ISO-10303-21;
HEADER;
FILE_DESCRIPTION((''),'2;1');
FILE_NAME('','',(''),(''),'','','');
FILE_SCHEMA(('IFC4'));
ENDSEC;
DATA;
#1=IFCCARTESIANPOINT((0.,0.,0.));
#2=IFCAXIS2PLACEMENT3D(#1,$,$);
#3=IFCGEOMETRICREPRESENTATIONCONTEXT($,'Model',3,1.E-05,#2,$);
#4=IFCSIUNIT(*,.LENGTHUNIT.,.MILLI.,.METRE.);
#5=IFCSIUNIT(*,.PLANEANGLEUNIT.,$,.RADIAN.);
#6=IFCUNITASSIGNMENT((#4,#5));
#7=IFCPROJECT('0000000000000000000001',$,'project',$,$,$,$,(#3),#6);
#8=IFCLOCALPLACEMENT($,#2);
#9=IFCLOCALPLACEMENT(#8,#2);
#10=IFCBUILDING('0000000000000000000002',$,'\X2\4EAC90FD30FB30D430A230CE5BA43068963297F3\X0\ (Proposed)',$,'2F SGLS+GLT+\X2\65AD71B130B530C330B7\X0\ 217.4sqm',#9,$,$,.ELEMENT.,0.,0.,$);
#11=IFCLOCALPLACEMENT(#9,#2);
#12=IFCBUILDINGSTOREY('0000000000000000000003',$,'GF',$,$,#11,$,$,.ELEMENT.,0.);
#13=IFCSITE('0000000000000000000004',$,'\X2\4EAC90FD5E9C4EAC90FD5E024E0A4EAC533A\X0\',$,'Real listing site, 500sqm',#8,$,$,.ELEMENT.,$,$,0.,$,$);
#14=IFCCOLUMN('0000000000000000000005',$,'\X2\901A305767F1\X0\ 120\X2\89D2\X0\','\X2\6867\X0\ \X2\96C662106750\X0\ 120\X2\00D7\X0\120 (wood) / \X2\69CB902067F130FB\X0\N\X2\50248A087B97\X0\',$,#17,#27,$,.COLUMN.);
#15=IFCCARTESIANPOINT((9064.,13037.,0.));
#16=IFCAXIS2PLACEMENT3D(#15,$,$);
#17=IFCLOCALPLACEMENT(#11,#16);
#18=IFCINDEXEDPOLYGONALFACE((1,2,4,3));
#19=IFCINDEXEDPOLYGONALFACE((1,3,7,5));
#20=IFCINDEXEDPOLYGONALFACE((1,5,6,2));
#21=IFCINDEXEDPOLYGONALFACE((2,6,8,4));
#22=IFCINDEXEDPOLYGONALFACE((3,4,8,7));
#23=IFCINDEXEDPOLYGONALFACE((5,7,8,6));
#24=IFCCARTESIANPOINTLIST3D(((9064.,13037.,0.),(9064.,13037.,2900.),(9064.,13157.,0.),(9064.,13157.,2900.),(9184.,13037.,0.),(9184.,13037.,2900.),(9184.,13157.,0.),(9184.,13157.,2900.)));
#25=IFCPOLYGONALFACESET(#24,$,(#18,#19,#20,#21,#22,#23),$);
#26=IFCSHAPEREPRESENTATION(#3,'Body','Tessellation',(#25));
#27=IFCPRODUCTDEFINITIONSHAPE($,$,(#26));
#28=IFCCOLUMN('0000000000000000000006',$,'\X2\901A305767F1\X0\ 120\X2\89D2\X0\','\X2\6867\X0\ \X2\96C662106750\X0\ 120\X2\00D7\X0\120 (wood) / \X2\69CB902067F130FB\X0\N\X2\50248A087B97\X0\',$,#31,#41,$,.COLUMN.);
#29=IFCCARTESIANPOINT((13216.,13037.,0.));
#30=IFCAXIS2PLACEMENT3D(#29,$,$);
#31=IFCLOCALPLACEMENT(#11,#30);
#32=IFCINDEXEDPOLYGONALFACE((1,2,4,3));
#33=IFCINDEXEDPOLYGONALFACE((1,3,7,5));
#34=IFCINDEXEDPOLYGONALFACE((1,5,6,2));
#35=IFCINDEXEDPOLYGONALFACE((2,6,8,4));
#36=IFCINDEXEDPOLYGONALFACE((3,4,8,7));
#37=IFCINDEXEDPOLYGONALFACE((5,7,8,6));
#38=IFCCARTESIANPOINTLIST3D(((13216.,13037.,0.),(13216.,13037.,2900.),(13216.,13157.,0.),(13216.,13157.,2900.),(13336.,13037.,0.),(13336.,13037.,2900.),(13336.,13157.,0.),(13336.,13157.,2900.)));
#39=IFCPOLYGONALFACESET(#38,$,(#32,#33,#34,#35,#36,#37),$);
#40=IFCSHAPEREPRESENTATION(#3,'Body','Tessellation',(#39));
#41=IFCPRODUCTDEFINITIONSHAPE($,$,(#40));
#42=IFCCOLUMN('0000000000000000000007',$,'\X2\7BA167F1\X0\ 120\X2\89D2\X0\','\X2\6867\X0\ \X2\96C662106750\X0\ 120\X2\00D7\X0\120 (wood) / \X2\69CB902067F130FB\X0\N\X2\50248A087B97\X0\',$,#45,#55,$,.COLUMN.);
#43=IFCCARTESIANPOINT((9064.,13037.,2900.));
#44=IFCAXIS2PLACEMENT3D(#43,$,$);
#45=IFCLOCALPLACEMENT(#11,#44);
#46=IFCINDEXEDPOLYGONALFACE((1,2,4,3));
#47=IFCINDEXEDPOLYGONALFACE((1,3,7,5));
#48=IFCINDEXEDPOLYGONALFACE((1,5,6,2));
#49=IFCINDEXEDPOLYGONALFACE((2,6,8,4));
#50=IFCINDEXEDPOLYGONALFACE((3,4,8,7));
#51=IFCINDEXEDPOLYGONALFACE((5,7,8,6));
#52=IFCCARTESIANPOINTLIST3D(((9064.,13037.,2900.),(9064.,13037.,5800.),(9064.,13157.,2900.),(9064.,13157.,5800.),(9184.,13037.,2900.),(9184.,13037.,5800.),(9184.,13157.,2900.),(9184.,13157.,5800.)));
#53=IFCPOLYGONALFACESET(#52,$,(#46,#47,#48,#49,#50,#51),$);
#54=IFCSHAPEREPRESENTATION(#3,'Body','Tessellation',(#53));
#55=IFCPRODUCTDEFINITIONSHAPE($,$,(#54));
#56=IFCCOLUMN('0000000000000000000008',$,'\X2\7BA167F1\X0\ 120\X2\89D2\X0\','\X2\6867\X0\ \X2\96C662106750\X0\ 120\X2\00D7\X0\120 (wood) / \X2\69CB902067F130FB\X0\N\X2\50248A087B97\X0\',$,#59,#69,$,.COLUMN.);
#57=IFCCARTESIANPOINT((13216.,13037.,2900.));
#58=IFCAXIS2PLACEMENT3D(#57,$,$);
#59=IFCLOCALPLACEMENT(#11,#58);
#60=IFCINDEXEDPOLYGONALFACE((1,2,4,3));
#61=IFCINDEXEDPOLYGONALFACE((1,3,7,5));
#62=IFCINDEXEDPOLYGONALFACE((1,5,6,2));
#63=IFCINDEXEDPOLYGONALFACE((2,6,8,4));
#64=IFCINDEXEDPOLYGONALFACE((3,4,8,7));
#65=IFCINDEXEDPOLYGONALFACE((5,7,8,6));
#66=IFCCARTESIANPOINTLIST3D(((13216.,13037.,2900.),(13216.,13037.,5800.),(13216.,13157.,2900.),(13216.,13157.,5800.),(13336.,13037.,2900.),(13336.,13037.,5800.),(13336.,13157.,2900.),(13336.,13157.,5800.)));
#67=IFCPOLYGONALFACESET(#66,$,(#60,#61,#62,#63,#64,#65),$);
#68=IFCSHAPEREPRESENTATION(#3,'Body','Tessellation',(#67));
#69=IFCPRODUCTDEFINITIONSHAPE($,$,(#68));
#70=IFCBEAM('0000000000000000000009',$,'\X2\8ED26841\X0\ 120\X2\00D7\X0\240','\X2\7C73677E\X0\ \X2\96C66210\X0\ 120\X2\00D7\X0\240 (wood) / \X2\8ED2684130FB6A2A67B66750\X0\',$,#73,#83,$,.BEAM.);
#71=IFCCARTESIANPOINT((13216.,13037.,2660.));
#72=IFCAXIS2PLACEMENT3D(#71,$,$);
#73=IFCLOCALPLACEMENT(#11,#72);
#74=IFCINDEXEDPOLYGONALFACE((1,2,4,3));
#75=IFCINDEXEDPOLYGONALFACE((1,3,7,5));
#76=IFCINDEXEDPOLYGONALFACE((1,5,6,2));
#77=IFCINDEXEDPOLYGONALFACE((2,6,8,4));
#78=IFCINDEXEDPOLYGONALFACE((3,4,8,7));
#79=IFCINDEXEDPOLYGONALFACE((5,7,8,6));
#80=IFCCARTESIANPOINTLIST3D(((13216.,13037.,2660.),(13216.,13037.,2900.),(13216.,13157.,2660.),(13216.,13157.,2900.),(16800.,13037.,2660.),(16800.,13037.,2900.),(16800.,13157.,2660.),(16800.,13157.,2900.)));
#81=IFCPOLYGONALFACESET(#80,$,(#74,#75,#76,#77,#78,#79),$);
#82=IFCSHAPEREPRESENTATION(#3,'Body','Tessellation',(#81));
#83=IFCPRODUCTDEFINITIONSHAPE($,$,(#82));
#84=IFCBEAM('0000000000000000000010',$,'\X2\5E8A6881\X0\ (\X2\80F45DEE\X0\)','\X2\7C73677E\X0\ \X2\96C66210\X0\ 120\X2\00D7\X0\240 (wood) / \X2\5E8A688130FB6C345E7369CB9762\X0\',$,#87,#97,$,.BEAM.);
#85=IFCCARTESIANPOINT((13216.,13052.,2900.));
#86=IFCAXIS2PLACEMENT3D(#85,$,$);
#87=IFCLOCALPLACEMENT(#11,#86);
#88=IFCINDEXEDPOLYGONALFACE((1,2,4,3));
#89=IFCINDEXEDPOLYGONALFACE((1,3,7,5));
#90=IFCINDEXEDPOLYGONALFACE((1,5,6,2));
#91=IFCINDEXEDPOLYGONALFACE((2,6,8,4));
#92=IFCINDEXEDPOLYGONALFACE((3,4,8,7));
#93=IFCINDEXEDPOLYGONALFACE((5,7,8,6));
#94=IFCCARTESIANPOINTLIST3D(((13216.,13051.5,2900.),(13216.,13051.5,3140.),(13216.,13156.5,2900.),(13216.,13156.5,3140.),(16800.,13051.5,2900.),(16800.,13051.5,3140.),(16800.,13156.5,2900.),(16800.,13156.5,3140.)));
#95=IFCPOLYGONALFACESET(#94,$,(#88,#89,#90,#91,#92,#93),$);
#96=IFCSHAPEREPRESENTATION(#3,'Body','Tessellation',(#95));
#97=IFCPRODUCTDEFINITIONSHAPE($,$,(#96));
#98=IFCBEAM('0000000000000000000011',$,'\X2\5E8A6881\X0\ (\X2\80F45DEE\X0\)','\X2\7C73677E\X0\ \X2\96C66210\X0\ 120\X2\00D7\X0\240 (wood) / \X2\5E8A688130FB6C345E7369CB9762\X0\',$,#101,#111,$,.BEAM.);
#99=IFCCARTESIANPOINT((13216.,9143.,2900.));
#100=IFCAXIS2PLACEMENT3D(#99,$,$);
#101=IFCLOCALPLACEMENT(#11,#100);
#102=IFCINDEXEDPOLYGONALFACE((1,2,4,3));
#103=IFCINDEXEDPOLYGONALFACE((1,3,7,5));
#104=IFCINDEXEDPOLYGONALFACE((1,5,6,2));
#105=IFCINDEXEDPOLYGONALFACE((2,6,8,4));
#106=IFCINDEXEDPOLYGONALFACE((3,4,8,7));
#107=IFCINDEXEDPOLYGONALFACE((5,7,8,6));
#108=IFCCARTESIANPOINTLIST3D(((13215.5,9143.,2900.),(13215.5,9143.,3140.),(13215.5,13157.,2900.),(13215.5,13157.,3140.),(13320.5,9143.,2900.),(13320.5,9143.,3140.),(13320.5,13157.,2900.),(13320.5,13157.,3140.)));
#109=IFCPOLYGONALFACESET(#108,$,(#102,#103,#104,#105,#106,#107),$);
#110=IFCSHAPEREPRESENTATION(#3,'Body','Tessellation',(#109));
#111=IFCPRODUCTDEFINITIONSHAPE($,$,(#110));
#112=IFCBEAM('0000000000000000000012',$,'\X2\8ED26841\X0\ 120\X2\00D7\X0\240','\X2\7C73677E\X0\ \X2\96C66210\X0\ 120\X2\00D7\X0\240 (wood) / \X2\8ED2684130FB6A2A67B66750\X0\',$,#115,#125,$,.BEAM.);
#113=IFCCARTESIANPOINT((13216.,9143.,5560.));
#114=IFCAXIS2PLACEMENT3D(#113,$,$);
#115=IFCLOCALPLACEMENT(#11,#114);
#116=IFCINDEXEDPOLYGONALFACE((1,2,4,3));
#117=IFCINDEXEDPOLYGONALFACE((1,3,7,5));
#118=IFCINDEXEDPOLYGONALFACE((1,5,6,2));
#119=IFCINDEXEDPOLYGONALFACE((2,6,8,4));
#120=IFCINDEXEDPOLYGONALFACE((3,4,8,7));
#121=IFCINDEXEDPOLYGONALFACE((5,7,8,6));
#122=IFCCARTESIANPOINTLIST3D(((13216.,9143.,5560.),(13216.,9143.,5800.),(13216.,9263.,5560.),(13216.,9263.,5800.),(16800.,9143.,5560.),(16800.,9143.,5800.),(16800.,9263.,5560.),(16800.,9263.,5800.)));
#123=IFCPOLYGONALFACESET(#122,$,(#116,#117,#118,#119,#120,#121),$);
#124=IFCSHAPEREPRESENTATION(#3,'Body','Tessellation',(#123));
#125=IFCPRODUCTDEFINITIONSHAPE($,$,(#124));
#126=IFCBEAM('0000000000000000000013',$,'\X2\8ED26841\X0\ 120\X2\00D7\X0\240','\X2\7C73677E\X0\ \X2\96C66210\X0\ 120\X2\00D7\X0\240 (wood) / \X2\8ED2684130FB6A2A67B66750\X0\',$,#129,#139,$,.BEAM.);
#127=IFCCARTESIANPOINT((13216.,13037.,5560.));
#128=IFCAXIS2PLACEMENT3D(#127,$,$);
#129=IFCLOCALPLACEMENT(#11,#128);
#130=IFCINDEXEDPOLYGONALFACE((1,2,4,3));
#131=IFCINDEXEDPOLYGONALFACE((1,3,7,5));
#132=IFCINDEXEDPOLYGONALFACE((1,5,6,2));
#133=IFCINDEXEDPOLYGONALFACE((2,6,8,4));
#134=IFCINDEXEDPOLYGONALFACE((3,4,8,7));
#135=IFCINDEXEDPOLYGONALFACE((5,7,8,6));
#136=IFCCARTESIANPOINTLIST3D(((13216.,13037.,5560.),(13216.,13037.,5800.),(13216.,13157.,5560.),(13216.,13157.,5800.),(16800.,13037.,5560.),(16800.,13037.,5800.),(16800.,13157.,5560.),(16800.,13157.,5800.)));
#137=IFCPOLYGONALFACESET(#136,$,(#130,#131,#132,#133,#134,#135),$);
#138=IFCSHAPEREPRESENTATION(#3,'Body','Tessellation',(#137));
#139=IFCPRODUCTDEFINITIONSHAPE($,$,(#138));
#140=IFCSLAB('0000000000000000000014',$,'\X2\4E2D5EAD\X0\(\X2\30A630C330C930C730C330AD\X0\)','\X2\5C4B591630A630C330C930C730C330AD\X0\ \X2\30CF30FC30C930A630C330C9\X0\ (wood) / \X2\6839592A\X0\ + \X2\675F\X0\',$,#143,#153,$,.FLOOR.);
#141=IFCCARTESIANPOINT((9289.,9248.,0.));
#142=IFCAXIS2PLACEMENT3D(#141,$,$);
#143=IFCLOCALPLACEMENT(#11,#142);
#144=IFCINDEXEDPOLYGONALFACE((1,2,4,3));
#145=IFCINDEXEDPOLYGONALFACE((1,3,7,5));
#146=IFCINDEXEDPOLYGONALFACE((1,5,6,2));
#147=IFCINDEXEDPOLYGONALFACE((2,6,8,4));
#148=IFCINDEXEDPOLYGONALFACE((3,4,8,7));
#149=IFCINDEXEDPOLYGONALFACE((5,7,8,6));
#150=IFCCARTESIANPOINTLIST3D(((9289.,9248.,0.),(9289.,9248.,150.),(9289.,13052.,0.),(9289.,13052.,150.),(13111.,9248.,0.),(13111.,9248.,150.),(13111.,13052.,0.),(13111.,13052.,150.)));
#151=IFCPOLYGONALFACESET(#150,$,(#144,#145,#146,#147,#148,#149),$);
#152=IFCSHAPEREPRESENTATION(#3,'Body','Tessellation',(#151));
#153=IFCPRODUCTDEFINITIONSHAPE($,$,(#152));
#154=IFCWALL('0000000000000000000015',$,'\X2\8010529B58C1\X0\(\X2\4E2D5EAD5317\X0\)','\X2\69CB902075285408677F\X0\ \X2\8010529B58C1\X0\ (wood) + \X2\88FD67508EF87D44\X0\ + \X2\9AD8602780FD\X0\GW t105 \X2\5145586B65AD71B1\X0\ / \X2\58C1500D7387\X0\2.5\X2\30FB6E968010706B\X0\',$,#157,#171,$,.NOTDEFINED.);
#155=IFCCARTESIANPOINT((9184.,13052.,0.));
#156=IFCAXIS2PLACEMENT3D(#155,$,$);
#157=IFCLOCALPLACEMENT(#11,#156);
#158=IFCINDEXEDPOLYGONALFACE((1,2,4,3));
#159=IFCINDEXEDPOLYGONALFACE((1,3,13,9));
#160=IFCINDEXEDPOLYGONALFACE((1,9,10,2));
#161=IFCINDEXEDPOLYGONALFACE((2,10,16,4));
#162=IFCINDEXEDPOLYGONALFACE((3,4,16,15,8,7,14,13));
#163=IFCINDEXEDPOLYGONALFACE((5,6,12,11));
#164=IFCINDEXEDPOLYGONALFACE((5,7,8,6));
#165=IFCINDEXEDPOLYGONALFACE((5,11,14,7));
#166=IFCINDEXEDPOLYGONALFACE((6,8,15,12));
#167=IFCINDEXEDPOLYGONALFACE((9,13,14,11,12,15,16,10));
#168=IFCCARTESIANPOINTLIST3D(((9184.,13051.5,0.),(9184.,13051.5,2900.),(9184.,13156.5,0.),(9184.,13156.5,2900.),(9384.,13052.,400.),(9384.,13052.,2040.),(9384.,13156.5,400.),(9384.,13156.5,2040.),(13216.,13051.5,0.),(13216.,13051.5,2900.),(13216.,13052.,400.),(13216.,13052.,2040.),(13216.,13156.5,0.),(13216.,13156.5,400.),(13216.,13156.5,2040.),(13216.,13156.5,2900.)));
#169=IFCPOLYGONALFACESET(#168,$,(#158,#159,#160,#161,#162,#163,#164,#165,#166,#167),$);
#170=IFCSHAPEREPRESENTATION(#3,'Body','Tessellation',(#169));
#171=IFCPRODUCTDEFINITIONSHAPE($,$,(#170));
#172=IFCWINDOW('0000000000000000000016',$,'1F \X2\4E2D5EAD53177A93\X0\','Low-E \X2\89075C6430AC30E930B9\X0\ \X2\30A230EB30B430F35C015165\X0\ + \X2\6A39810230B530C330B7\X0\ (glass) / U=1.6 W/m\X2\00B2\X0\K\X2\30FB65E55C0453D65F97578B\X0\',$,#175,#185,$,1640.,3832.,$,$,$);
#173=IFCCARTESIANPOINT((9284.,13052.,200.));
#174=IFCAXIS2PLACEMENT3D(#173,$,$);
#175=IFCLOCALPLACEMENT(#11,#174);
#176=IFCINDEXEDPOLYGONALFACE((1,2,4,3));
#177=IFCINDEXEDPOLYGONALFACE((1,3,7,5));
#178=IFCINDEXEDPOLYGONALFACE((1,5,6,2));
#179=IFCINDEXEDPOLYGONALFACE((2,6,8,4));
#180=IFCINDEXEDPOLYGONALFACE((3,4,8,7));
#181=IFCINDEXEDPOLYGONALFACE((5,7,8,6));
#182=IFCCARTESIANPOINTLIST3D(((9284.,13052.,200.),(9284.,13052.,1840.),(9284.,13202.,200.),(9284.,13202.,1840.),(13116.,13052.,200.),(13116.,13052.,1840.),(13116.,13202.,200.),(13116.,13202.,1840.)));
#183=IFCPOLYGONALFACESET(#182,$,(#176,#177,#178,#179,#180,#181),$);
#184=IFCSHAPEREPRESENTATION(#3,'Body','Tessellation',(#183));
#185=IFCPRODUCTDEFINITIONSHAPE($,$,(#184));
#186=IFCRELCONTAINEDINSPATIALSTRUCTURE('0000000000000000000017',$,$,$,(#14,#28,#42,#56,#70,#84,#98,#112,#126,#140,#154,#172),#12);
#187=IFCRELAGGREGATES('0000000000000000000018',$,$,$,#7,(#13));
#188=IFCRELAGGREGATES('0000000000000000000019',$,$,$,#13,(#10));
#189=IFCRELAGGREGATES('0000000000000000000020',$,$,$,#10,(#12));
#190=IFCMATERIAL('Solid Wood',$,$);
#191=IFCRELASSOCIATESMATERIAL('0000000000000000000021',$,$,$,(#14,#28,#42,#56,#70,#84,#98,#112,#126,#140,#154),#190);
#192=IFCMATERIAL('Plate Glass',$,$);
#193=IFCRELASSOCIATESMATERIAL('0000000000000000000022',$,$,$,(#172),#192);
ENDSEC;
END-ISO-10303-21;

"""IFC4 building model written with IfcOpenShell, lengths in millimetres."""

from ifc_helpers import new_model, si_unit, frame, frame_2d, origin, place, context, project, spatial, rectangle, extrude, material, element, fill, save


model = new_model("IFC4")

# Units and contexts
model_context = context("Model", 3, precision=1e-05, world=origin())
ifc_project = project(units=[si_unit("LENGTHUNIT", "METRE", prefix="MILLI"), si_unit("PLANEANGLEUNIT", "RADIAN")], contexts=[model_context])

# Site, building, storey
site_placement = place(None, origin())
site = spatial("IfcSite", under=ifc_project, at=site_placement, Name="京都府京都市上京区", ObjectType="Real listing site, 500sqm", CompositionType="ELEMENT", RefElevation=0.0)
building_placement = place(site_placement, origin())
building = spatial("IfcBuilding", under=site, at=building_placement, Name="京都・ピアノ室と防音 (Proposed)", ObjectType="2F SGLS+GLT+断熱サッシ 217.4sqm", CompositionType="ELEMENT", ElevationOfRefHeight=0.0, ElevationOfTerrain=0.0)
storey_placement = place(building_placement, origin())
storey = spatial("IfcBuildingStorey", under=building, at=storey_placement, Name="GF", CompositionType="ELEMENT", Elevation=0.0)

# Columns
ifc_material_1 = material(Name="Solid Wood")
column_1_placement = place(storey_placement, frame((9064.0, 13037.0, 0.0)))
element("IfcColumn", 1, at=column_1_placement, inside=storey, material=ifc_material_1, Name="通し柱 120角", Description="桧 集成材 120×120 (wood) / 構造柱・N値計算", PredefinedType="COLUMN", context=model_context, shape_type="SweptSolid", body=[
    extrude(rectangle(XDim=120.0, YDim=120.0, at=frame_2d((60.0, 60.0))), frame((9064.0, 13037.0, 0.0)), (0.0, 0.0, 1.0), 2900.0),
])
column_2_placement = place(storey_placement, frame((13216.0, 13037.0, 0.0)))
element("IfcColumn", 2, at=column_2_placement, inside=storey, material=ifc_material_1, Name="通し柱 120角", Description="桧 集成材 120×120 (wood) / 構造柱・N値計算", PredefinedType="COLUMN", context=model_context, shape_type="SweptSolid", body=[
    extrude(rectangle(XDim=120.0, YDim=120.0, at=frame_2d((60.0, 60.0))), frame((13216.0, 13037.0, 0.0)), (0.0, 0.0, 1.0), 2900.0),
])
column_3_placement = place(storey_placement, frame((9064.0, 13037.0, 2900.0)))
element("IfcColumn", 3, at=column_3_placement, inside=storey, material=ifc_material_1, Name="管柱 120角", Description="桧 集成材 120×120 (wood) / 構造柱・N値計算", PredefinedType="COLUMN", context=model_context, shape_type="SweptSolid", body=[
    extrude(rectangle(XDim=120.0, YDim=120.0, at=frame_2d((60.0, 60.0))), frame((9064.0, 13037.0, 2900.0)), (0.0, 0.0, 1.0), 2900.0),
])
column_4_placement = place(storey_placement, frame((13216.0, 13037.0, 2900.0)))
element("IfcColumn", 4, at=column_4_placement, inside=storey, material=ifc_material_1, Name="管柱 120角", Description="桧 集成材 120×120 (wood) / 構造柱・N値計算", PredefinedType="COLUMN", context=model_context, shape_type="SweptSolid", body=[
    extrude(rectangle(XDim=120.0, YDim=120.0, at=frame_2d((60.0, 60.0))), frame((13216.0, 13037.0, 2900.0)), (0.0, 0.0, 1.0), 2900.0),
])

# Beams
beam_1_placement = place(storey_placement, frame((13216.0, 13037.0, 2660.0)))
element("IfcBeam", 5, at=beam_1_placement, inside=storey, material=ifc_material_1, Name="軒桁 120×240", Description="米松 集成 120×240 (wood) / 軒桁・横架材", PredefinedType="BEAM", context=model_context, shape_type="SweptSolid", body=[
    extrude(rectangle(XDim=3584.0, YDim=120.0, at=frame_2d((1792.0, 60.0))), frame((13216.0, 13037.0, 2660.0)), (0.0, 0.0, 1.0), 240.0),
])
beam_2_placement = place(storey_placement, frame((13216.0, 13052.0, 2900.0)))
element("IfcBeam", 6, at=beam_2_placement, inside=storey, material=ifc_material_1, Name="床梁 (胴差)", Description="米松 集成 120×240 (wood) / 床梁・水平構面", PredefinedType="BEAM", context=model_context, shape_type="SweptSolid", body=[
    extrude(rectangle(XDim=3584.0, YDim=105.0, at=frame_2d((1792.0, 52.0))), frame((13216.0, 13052.0, 2900.0)), (0.0, 0.0, 1.0), 240.0),
])
beam_3_placement = place(storey_placement, frame((13216.0, 9143.0, 2900.0)))
element("IfcBeam", 7, at=beam_3_placement, inside=storey, material=ifc_material_1, Name="床梁 (胴差)", Description="米松 集成 120×240 (wood) / 床梁・水平構面", PredefinedType="BEAM", context=model_context, shape_type="SweptSolid", body=[
    extrude(rectangle(XDim=105.0, YDim=4014.0, at=frame_2d((52.0, 2007.0))), frame((13216.0, 9143.0, 2900.0)), (0.0, 0.0, 1.0), 240.0),
])
beam_4_placement = place(storey_placement, frame((13216.0, 9143.0, 5560.0)))
element("IfcBeam", 8, at=beam_4_placement, inside=storey, material=ifc_material_1, Name="軒桁 120×240", Description="米松 集成 120×240 (wood) / 軒桁・横架材", PredefinedType="BEAM", context=model_context, shape_type="SweptSolid", body=[
    extrude(rectangle(XDim=3584.0, YDim=120.0, at=frame_2d((1792.0, 60.0))), frame((13216.0, 9143.0, 5560.0)), (0.0, 0.0, 1.0), 240.0),
])
beam_5_placement = place(storey_placement, frame((13216.0, 13037.0, 5560.0)))
element("IfcBeam", 9, at=beam_5_placement, inside=storey, material=ifc_material_1, Name="軒桁 120×240", Description="米松 集成 120×240 (wood) / 軒桁・横架材", PredefinedType="BEAM", context=model_context, shape_type="SweptSolid", body=[
    extrude(rectangle(XDim=3584.0, YDim=120.0, at=frame_2d((1792.0, 60.0))), frame((13216.0, 13037.0, 5560.0)), (0.0, 0.0, 1.0), 240.0),
])

# Slab
slab_placement = place(storey_placement, frame((9289.0, 9248.0, 0.0)))
element("IfcSlab", 10, at=slab_placement, inside=storey, material=ifc_material_1, Name="中庭(ウッドデッキ)", Description="屋外ウッドデッキ ハードウッド (wood) / 根太 + 束", PredefinedType="FLOOR", context=model_context, shape_type="SweptSolid", body=[
    extrude(rectangle(XDim=3822.0, YDim=3804.0, at=frame_2d((1911.0, 1902.0))), frame((9289.0, 9248.0, 0.0)), (0.0, 0.0, 1.0), 150.0),
])

# Wall, opening, window
wall_1_placement = place(storey_placement, frame((9184.0, 13052.0, 0.0)))
wall_1 = element("IfcWall", 11, at=wall_1_placement, inside=storey, material=ifc_material_1, Name="耐力壁(中庭北)", Description="構造用合板 耐力壁 (wood) + 製材軸組 + 高性能GW t105 充填断熱 / 壁倍率2.5・準耐火", PredefinedType="NOTDEFINED", context=model_context, shape_type="SweptSolid", body=[
    extrude(rectangle(XDim=4032.0, YDim=105.0, at=frame_2d((2016.0, 52.0))), frame((9184.0, 13052.0, 0.0)), (0.0, 0.0, 1.0), 2900.0),
])
opening_1_placement = place(storey_placement, frame((9284.0, 13052.0, 200.0)))
opening_1 = element("IfcOpeningElement", 12, at=opening_1_placement, cuts=wall_1, PredefinedType="NOTDEFINED", context=model_context, shape_type="SweptSolid", body=[
    extrude(rectangle(XDim=3832.0, YDim=150.0, at=frame_2d((1916.0, 75.0))), frame((9284.0, 13052.0, 200.0)), (0.0, 0.0, 1.0), 1640.0),
])
ifc_material_2 = material(Name="Plate Glass")
window_1_placement = place(storey_placement, frame((9284.0, 13052.0, 200.0)))
window_1 = element("IfcWindow", 13, at=window_1_placement, inside=storey, material=ifc_material_2, Name="1F 中庭北窓", Description="Low-E 複層ガラス アルゴン封入 + 樹脂サッシ (glass) / U=1.6 W/m²K・日射取得型", OverallHeight=1640.0, OverallWidth=3832.0, context=model_context, shape_type="SweptSolid", body=[
    extrude(rectangle(XDim=3832.0, YDim=150.0, at=frame_2d((1916.0, 75.0))), frame((9284.0, 13052.0, 200.0)), (0.0, 0.0, 1.0), 1640.0),
])
fill(opening_1, window_1)

save(model, "model.ifc")
